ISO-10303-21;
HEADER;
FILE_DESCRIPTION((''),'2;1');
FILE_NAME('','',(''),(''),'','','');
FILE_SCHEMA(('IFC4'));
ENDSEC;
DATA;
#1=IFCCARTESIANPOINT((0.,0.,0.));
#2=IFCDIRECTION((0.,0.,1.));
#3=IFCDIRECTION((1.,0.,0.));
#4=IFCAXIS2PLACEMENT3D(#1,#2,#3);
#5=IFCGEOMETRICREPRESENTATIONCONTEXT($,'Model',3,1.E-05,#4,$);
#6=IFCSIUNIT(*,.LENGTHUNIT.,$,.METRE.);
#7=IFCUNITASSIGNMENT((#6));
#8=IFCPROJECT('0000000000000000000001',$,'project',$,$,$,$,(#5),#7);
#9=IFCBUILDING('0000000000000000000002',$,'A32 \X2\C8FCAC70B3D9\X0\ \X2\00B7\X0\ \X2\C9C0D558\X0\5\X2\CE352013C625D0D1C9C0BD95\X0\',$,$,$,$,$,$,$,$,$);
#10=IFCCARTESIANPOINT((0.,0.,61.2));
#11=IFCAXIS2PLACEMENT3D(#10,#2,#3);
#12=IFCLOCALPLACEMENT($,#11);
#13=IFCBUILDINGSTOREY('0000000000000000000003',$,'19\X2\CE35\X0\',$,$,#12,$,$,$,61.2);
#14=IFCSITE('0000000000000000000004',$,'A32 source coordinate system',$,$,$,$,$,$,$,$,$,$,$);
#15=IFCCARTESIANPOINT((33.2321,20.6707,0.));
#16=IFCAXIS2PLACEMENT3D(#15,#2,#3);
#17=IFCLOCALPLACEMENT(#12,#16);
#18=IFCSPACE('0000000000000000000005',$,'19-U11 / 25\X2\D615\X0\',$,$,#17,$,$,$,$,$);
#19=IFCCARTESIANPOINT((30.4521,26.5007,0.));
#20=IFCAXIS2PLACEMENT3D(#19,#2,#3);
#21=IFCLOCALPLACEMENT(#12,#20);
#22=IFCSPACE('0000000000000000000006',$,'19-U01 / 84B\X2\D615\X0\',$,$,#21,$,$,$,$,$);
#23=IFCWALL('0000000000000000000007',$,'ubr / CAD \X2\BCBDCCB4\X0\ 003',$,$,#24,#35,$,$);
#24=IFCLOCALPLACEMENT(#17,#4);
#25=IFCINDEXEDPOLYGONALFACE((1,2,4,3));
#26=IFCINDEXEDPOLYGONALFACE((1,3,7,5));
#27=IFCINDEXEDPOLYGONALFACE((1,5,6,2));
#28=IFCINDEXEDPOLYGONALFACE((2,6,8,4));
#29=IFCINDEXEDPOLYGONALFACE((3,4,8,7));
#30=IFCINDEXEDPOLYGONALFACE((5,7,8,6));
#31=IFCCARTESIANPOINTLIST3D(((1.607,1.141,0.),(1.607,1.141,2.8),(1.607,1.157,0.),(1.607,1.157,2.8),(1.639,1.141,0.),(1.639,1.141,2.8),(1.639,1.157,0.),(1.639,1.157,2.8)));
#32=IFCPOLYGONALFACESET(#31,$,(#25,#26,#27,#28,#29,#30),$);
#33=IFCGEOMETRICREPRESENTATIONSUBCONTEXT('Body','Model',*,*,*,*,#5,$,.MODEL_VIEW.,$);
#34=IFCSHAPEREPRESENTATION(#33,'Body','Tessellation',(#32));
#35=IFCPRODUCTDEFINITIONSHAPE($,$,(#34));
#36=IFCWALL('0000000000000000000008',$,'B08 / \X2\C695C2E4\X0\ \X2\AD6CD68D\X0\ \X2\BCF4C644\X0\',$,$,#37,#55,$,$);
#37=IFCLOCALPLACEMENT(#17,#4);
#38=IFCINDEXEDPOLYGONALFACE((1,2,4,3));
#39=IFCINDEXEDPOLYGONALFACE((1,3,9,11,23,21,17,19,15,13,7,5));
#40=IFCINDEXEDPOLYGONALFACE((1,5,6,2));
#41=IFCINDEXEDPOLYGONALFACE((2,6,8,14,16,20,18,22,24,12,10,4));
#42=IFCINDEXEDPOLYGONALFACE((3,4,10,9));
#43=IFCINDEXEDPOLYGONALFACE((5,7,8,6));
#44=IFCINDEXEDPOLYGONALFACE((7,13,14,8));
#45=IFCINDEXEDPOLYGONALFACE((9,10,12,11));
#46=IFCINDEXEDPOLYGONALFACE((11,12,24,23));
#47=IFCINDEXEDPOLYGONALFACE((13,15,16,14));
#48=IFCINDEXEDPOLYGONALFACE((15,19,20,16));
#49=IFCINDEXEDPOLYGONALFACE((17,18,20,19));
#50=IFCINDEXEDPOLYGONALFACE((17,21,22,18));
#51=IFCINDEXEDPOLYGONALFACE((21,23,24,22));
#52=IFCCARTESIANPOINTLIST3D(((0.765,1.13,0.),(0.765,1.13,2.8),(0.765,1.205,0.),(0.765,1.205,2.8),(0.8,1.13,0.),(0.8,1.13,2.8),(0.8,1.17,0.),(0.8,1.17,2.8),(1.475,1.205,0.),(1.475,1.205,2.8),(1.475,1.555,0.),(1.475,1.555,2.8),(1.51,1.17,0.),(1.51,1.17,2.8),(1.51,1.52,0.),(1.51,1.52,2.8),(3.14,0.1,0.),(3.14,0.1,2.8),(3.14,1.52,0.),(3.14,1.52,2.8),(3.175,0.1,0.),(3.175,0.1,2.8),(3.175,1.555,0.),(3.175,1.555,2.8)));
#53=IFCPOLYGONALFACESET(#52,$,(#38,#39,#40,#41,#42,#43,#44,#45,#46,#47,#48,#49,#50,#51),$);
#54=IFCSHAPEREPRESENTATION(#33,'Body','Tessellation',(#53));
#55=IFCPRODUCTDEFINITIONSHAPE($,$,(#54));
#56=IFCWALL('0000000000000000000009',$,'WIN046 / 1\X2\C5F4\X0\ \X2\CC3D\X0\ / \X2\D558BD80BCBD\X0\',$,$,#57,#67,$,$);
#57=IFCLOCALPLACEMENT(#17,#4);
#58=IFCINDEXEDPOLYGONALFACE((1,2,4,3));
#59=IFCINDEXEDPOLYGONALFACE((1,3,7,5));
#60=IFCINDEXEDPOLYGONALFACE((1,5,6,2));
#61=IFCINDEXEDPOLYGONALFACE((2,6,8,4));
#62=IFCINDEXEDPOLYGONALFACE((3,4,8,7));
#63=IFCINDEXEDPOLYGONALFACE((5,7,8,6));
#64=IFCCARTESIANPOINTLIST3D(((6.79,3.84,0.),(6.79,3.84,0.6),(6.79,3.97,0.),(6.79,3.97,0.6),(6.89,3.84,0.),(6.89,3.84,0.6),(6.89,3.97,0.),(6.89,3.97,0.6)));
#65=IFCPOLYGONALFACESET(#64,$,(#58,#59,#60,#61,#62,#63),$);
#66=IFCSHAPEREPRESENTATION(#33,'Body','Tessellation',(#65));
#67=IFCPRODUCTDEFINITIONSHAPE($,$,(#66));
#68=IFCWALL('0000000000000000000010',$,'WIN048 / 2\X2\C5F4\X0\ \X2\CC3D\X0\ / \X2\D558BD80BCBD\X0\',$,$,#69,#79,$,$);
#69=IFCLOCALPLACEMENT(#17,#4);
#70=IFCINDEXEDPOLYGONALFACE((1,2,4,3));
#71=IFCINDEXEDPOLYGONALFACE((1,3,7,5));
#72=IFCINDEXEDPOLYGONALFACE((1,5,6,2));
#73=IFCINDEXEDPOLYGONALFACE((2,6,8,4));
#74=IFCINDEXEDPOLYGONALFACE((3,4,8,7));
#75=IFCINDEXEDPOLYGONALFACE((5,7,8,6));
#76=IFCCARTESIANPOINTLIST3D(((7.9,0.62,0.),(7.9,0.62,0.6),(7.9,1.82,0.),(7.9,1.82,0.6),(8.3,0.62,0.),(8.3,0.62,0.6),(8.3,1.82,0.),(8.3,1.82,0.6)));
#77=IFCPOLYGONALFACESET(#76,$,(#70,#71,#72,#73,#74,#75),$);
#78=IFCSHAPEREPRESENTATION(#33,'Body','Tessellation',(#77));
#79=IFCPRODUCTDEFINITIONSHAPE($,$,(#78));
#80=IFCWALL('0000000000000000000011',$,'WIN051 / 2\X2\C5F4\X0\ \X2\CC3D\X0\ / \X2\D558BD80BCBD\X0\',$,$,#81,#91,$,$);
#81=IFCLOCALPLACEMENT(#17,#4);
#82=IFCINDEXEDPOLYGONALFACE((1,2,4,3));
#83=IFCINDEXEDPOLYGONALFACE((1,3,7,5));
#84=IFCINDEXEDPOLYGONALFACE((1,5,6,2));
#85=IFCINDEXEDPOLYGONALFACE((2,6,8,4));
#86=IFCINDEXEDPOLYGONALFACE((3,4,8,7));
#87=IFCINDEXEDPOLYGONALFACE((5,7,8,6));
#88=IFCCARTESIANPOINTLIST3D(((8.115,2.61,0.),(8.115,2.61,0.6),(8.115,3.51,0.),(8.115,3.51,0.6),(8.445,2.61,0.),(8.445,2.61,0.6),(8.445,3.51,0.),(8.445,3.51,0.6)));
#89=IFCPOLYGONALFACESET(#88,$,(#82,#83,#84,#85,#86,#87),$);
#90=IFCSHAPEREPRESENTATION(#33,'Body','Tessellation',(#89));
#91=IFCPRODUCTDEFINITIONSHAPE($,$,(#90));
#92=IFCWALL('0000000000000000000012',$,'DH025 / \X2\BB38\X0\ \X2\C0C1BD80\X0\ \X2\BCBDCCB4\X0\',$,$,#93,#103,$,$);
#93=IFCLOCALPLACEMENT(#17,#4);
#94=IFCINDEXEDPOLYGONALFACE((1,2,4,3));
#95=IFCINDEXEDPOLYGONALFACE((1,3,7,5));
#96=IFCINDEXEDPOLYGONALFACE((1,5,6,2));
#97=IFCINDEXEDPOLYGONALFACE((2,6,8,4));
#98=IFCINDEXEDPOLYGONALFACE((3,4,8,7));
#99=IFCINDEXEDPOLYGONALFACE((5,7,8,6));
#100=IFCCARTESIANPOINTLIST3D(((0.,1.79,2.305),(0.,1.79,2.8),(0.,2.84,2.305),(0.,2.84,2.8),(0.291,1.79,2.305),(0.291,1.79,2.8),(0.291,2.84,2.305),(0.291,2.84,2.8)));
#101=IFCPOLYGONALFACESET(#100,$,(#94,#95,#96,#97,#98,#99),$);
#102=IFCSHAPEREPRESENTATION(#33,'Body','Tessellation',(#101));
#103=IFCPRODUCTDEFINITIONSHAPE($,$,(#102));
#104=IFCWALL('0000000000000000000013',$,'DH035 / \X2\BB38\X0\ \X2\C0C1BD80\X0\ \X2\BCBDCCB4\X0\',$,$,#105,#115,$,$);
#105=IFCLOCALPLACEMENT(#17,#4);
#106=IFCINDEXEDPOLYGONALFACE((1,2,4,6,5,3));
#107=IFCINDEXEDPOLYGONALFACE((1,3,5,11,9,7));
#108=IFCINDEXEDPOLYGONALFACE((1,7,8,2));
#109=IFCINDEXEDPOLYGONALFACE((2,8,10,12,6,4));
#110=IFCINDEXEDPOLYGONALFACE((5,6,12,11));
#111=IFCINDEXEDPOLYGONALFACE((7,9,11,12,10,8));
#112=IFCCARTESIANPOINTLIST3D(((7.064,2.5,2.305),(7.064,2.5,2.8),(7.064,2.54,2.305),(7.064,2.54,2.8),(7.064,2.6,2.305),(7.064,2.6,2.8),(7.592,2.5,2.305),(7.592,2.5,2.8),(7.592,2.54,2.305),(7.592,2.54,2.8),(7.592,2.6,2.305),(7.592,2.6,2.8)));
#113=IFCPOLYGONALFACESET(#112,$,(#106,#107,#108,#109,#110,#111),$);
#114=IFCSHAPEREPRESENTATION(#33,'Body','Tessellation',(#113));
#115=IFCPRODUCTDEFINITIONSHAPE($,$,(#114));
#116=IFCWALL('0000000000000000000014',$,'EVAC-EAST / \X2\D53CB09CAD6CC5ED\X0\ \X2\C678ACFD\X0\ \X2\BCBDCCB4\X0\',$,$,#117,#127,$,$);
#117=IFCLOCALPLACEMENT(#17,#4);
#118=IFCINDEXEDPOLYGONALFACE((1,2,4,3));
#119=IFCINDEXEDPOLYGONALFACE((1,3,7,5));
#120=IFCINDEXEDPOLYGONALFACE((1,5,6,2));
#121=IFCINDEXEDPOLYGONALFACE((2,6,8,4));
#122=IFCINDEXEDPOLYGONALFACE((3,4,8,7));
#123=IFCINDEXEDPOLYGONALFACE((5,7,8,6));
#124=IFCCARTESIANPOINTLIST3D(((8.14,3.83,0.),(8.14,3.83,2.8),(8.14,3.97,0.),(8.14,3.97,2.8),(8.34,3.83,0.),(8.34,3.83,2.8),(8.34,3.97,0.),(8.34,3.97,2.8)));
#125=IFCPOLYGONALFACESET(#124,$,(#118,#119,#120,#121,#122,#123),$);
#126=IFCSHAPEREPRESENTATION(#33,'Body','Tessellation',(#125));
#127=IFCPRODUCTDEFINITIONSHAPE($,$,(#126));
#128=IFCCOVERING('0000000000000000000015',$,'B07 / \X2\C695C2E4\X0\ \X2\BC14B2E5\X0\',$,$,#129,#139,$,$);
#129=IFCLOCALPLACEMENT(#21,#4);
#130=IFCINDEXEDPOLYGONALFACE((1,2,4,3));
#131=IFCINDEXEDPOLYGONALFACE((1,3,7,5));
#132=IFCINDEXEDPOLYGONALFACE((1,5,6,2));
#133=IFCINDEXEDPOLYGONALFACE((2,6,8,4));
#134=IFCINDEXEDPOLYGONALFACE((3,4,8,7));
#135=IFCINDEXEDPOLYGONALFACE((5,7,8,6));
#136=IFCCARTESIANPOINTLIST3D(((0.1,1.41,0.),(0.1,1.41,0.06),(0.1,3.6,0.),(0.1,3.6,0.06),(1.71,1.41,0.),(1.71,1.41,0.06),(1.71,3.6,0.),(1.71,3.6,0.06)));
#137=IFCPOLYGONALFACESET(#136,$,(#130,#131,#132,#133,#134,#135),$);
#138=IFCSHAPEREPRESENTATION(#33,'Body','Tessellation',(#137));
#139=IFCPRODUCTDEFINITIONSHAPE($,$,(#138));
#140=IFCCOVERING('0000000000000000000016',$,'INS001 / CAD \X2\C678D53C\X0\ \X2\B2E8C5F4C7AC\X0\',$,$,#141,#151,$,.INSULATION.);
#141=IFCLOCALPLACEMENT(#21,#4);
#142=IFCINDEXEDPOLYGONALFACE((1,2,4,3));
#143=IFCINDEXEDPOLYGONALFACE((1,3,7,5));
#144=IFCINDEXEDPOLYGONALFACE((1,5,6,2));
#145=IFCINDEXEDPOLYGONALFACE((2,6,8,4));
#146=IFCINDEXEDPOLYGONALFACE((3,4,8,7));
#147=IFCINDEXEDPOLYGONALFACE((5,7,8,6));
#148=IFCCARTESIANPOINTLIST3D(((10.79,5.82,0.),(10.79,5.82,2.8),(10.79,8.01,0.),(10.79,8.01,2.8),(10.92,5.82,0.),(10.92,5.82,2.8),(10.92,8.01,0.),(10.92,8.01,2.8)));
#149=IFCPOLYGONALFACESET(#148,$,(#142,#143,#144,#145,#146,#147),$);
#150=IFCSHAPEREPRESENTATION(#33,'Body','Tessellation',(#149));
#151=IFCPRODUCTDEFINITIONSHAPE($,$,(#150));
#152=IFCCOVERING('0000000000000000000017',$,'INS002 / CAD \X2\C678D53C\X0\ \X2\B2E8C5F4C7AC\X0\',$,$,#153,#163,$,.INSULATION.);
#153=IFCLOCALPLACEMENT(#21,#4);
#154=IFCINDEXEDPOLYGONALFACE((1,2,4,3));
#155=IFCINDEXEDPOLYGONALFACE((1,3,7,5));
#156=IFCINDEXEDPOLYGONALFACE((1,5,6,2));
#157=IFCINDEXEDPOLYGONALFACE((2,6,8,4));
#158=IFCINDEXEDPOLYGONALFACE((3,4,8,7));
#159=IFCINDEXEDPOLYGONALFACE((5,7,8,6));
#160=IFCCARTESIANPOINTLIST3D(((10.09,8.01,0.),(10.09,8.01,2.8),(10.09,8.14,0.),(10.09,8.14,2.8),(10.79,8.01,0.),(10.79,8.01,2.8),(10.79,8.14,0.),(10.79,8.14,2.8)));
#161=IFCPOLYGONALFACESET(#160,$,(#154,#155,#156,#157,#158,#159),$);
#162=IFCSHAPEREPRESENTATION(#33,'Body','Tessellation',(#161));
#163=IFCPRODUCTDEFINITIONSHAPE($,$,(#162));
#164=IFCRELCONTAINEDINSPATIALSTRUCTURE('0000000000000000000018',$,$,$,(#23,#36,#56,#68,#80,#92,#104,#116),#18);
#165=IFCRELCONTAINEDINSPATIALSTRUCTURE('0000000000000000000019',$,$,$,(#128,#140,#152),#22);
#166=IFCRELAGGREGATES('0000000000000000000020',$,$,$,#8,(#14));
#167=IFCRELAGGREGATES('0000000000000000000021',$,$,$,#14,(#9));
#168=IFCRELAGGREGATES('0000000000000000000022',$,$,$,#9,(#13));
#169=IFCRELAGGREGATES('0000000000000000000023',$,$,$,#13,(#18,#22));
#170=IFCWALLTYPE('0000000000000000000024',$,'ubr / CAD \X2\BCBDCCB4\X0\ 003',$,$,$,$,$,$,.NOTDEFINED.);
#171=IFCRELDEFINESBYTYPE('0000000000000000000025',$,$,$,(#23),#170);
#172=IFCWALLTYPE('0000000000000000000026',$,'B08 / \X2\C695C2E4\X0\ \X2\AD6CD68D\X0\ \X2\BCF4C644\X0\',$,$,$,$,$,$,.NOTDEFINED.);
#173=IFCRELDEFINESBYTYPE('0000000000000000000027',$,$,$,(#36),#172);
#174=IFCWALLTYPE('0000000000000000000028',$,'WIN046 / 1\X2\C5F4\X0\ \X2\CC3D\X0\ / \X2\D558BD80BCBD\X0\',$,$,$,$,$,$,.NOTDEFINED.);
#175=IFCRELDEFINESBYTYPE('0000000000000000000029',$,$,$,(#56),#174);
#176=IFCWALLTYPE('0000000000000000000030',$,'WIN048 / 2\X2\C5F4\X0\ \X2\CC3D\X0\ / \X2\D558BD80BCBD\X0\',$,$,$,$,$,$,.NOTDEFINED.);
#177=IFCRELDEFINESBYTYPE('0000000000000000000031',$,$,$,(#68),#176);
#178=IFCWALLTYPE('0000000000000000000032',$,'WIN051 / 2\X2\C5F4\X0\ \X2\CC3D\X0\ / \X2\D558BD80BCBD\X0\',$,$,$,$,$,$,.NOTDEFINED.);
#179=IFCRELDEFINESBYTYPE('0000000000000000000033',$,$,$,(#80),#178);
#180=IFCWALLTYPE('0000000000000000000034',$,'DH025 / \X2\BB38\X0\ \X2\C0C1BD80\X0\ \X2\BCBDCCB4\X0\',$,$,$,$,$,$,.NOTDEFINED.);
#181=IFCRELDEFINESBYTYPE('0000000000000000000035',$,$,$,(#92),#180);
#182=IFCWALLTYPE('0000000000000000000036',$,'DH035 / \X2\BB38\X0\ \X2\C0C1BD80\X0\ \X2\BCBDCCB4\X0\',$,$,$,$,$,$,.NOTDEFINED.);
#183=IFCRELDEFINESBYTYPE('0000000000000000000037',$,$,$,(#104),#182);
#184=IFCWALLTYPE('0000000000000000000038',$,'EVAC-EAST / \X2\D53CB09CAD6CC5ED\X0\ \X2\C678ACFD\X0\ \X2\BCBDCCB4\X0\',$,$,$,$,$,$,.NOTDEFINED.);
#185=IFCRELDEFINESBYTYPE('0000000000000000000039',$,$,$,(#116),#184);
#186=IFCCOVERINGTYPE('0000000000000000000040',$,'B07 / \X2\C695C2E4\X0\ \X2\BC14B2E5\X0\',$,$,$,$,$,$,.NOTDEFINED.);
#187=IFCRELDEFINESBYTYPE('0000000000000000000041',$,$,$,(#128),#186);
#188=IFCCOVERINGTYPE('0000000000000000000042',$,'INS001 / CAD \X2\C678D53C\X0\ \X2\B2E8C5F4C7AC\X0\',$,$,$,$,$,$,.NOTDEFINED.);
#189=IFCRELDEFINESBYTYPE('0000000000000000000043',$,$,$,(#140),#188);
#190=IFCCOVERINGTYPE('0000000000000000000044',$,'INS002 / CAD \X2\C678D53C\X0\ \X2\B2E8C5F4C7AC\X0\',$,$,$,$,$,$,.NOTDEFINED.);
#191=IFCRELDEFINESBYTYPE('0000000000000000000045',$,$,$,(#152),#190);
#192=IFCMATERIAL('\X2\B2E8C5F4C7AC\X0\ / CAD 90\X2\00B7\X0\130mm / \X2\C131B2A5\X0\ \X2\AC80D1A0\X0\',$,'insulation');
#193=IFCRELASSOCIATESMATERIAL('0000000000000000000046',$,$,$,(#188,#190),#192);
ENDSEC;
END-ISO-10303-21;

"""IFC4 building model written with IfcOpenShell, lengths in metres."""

from ifc_helpers import new_model, si_unit, frame, origin, origin_with_axes, place, context, subcontext, project, spatial, polyline, outline, extrude, source, transform, mapped, material, type_object, type_shapes, element, save


model = new_model("IFC4")

# Units and contexts
model_context = context("Model", 3, precision=1e-05, world=origin_with_axes())
body_context = subcontext(model_context, "Body", "Model", "MODEL_VIEW")
ifc_project = project(units=[si_unit("LENGTHUNIT", "METRE")], contexts=[model_context])

# Site, building, storey, space
site = spatial("IfcSite", under=ifc_project, Name="A32 source coordinate system")
building = spatial("IfcBuilding", under=site, Name="A32 주거동 · 지하5층–옥탑지붕")
storey_placement = place(None, frame((0.0, 0.0, 61.2), z_axis=(0.0, 0.0, 1.0), x_axis=(1.0, 0.0, 0.0)))
storey = spatial("IfcBuildingStorey", under=building, at=storey_placement, Name="19층", Elevation=61.2)
space_1_placement = place(storey_placement, frame((33.2321, 20.6707, 0.0), z_axis=(0.0, 0.0, 1.0), x_axis=(1.0, 0.0, 0.0)))
space_1 = spatial("IfcSpace", under=storey, at=space_1_placement, Name="19-U11 / 25형")

# Walls
wall_type_1 = type_object("IfcWallType", Name="ubr / CAD 벽체 003", PredefinedType="NOTDEFINED")
shared_shape_1 = source(origin(), body_context, "Body", "SweptSolid", [
    extrude(outline(polyline([(1.639, 1.157), (1.639, 1.141), (1.607, 1.141), (1.607, 1.157), (1.639, 1.157)])), origin(), (0.0, 0.0, 1.0), 2.8),
])
type_shapes(wall_type_1, [shared_shape_1])
wall_1_placement = place(space_1_placement, origin_with_axes())
element("IfcWall", 1, at=wall_1_placement, inside=space_1, type_object=wall_type_1, Name="ubr / CAD 벽체 003", context=body_context, shape_type="MappedRepresentation", body=[
    mapped(shared_shape_1, transform((0.0, 0.0, 0.0), scale=1.0)),
])
wall_type_2 = type_object("IfcWallType", Name="B08 / 욕실 구획 보완", PredefinedType="NOTDEFINED")
shared_shape_2 = source(origin(), body_context, "Body", "SweptSolid", [
    extrude(outline(polyline([(0.765, 1.205), (1.475, 1.205), (1.475, 1.555), (3.175, 1.555), (3.175, 0.1), (3.14, 0.1), (3.14, 1.52), (1.51, 1.52), (1.51, 1.17), (0.8, 1.17), (0.8, 1.13), (0.765, 1.13), (0.765, 1.205)])), origin(), (0.0, 0.0, 1.0), 2.8),
])
type_shapes(wall_type_2, [shared_shape_2])
wall_2_placement = place(space_1_placement, origin_with_axes())
element("IfcWall", 2, at=wall_2_placement, inside=space_1, type_object=wall_type_2, Name="B08 / 욕실 구획 보완", context=body_context, shape_type="MappedRepresentation", body=[
    mapped(shared_shape_2, transform((0.0, 0.0, 0.0), scale=1.0)),
])
wall_type_3 = type_object("IfcWallType", Name="WIN046 / 1열 창 / 하부벽", PredefinedType="NOTDEFINED")
shared_shape_3 = source(origin(), body_context, "Body", "SweptSolid", [
    extrude(outline(polyline([(6.89, 3.84), (6.79, 3.84), (6.79, 3.97), (6.89, 3.97), (6.89, 3.84)])), origin(), (0.0, 0.0, 1.0), 0.6),
])
type_shapes(wall_type_3, [shared_shape_3])
wall_3_placement = place(space_1_placement, origin_with_axes())
element("IfcWall", 3, at=wall_3_placement, inside=space_1, type_object=wall_type_3, Name="WIN046 / 1열 창 / 하부벽", context=body_context, shape_type="MappedRepresentation", body=[
    mapped(shared_shape_3, transform((0.0, 0.0, 0.0), scale=1.0)),
])
wall_type_4 = type_object("IfcWallType", Name="WIN048 / 2열 창 / 하부벽", PredefinedType="NOTDEFINED")
shared_shape_4 = source(origin(), body_context, "Body", "SweptSolid", [
    extrude(outline(polyline([(8.3, 0.62), (7.9, 0.62), (7.9, 1.82), (8.3, 1.82), (8.3, 0.62)])), origin(), (0.0, 0.0, 1.0), 0.6),
])
type_shapes(wall_type_4, [shared_shape_4])
wall_4_placement = place(space_1_placement, origin_with_axes())
element("IfcWall", 4, at=wall_4_placement, inside=space_1, type_object=wall_type_4, Name="WIN048 / 2열 창 / 하부벽", context=body_context, shape_type="MappedRepresentation", body=[
    mapped(shared_shape_4, transform((0.0, 0.0, 0.0), scale=1.0)),
])
wall_type_5 = type_object("IfcWallType", Name="WIN051 / 2열 창 / 하부벽", PredefinedType="NOTDEFINED")
shared_shape_5 = source(origin(), body_context, "Body", "SweptSolid", [
    extrude(outline(polyline([(8.445, 2.61), (8.115, 2.61), (8.115, 3.51), (8.445, 3.51), (8.445, 2.61)])), origin(), (0.0, 0.0, 1.0), 0.6),
])
type_shapes(wall_type_5, [shared_shape_5])
wall_5_placement = place(space_1_placement, origin_with_axes())
element("IfcWall", 5, at=wall_5_placement, inside=space_1, type_object=wall_type_5, Name="WIN051 / 2열 창 / 하부벽", context=body_context, shape_type="MappedRepresentation", body=[
    mapped(shared_shape_5, transform((0.0, 0.0, 0.0), scale=1.0)),
])
wall_type_6 = type_object("IfcWallType", Name="DH025 / 문 상부 벽체", PredefinedType="NOTDEFINED")
shared_shape_6 = source(origin(), body_context, "Body", "SweptSolid", [
    extrude(outline(polyline([(0.0, 1.79), (0.0, 2.84), (0.291, 2.84), (0.291, 1.79), (0.0, 1.79)])), frame((0.0, 0.0, 2.305)), (0.0, 0.0, 1.0), 0.495),
])
type_shapes(wall_type_6, [shared_shape_6])
wall_6_placement = place(space_1_placement, origin_with_axes())
element("IfcWall", 6, at=wall_6_placement, inside=space_1, type_object=wall_type_6, Name="DH025 / 문 상부 벽체", context=body_context, shape_type="MappedRepresentation", body=[
    mapped(shared_shape_6, transform((0.0, 0.0, 0.0), scale=1.0)),
])
wall_type_7 = type_object("IfcWallType", Name="DH035 / 문 상부 벽체", PredefinedType="NOTDEFINED")
shared_shape_7 = source(origin(), body_context, "Body", "SweptSolid", [
    extrude(outline(polyline([(7.592, 2.6), (7.592, 2.54), (7.592, 2.5), (7.064, 2.5), (7.064, 2.54), (7.064, 2.6), (7.592, 2.6)])), frame((0.0, 0.0, 2.305)), (0.0, 0.0, 1.0), 0.495),
])
type_shapes(wall_type_7, [shared_shape_7])
wall_7_placement = place(space_1_placement, origin_with_axes())
element("IfcWall", 7, at=wall_7_placement, inside=space_1, type_object=wall_type_7, Name="DH035 / 문 상부 벽체", context=body_context, shape_type="MappedRepresentation", body=[
    mapped(shared_shape_7, transform((0.0, 0.0, 0.0), scale=1.0)),
])
wall_type_8 = type_object("IfcWallType", Name="EVAC-EAST / 피난구역 외곽 벽체", PredefinedType="NOTDEFINED")
shared_shape_8 = source(origin(), body_context, "Body", "SweptSolid", [
    extrude(outline(polyline([(8.34, 3.83), (8.14, 3.83), (8.14, 3.97), (8.34, 3.97), (8.34, 3.83)])), origin(), (0.0, 0.0, 1.0), 2.8),
])
type_shapes(wall_type_8, [shared_shape_8])
wall_8_placement = place(space_1_placement, origin_with_axes())
element("IfcWall", 8, at=wall_8_placement, inside=space_1, type_object=wall_type_8, Name="EVAC-EAST / 피난구역 외곽 벽체", context=body_context, shape_type="MappedRepresentation", body=[
    mapped(shared_shape_8, transform((0.0, 0.0, 0.0), scale=1.0)),
])

# Shared definitions
space_2_placement = place(storey_placement, frame((30.4521, 26.5007, 0.0), z_axis=(0.0, 0.0, 1.0), x_axis=(1.0, 0.0, 0.0)))
space_2 = spatial("IfcSpace", under=storey, at=space_2_placement, Name="19-U01 / 84B형")

# Coverings
covering_type_1 = type_object("IfcCoveringType", Name="B07 / 욕실 바닥", PredefinedType="NOTDEFINED")
shared_shape_9 = source(origin(), body_context, "Body", "SweptSolid", [
    extrude(outline(polyline([(1.71, 1.41), (0.1, 1.41), (0.1, 3.6), (1.71, 3.6), (1.71, 1.41)])), origin(), (0.0, 0.0, 1.0), 0.06),
])
type_shapes(covering_type_1, [shared_shape_9])
covering_1_placement = place(space_2_placement, origin_with_axes())
element("IfcCovering", 9, at=covering_1_placement, inside=space_2, type_object=covering_type_1, Name="B07 / 욕실 바닥", context=body_context, shape_type="MappedRepresentation", body=[
    mapped(shared_shape_9, transform((0.0, 0.0, 0.0), scale=1.0)),
])
ifc_material = material(Name="단열재 / CAD 90·130mm / 성능 검토", Category="insulation")
covering_type_2 = type_object("IfcCoveringType", Name="INS001 / CAD 외피 단열재", PredefinedType="NOTDEFINED", material=ifc_material)
shared_shape_10 = source(origin(), body_context, "Body", "SweptSolid", [
    extrude(outline(polyline([(10.79, 5.82), (10.79, 8.01), (10.92, 8.01), (10.92, 5.82), (10.79, 5.82)])), origin(), (0.0, 0.0, 1.0), 2.8),
])
type_shapes(covering_type_2, [shared_shape_10])
covering_2_placement = place(space_2_placement, origin_with_axes())
element("IfcCovering", 10, at=covering_2_placement, inside=space_2, type_object=covering_type_2, Name="INS001 / CAD 외피 단열재", PredefinedType="INSULATION", context=body_context, shape_type="MappedRepresentation", body=[
    mapped(shared_shape_10, transform((0.0, 0.0, 0.0), scale=1.0)),
])
covering_type_3 = type_object("IfcCoveringType", Name="INS002 / CAD 외피 단열재", PredefinedType="NOTDEFINED", material=ifc_material)
shared_shape_11 = source(origin(), body_context, "Body", "SweptSolid", [
    extrude(outline(polyline([(10.79, 8.01), (10.09, 8.01), (10.09, 8.14), (10.79, 8.14), (10.79, 8.01)])), origin(), (0.0, 0.0, 1.0), 2.8),
])
type_shapes(covering_type_3, [shared_shape_11])
covering_3_placement = place(space_2_placement, origin_with_axes())
element("IfcCovering", 11, at=covering_3_placement, inside=space_2, type_object=covering_type_3, Name="INS002 / CAD 외피 단열재", PredefinedType="INSULATION", context=body_context, shape_type="MappedRepresentation", body=[
    mapped(shared_shape_11, transform((0.0, 0.0, 0.0), scale=1.0)),
])

save(model, "model.ifc")
